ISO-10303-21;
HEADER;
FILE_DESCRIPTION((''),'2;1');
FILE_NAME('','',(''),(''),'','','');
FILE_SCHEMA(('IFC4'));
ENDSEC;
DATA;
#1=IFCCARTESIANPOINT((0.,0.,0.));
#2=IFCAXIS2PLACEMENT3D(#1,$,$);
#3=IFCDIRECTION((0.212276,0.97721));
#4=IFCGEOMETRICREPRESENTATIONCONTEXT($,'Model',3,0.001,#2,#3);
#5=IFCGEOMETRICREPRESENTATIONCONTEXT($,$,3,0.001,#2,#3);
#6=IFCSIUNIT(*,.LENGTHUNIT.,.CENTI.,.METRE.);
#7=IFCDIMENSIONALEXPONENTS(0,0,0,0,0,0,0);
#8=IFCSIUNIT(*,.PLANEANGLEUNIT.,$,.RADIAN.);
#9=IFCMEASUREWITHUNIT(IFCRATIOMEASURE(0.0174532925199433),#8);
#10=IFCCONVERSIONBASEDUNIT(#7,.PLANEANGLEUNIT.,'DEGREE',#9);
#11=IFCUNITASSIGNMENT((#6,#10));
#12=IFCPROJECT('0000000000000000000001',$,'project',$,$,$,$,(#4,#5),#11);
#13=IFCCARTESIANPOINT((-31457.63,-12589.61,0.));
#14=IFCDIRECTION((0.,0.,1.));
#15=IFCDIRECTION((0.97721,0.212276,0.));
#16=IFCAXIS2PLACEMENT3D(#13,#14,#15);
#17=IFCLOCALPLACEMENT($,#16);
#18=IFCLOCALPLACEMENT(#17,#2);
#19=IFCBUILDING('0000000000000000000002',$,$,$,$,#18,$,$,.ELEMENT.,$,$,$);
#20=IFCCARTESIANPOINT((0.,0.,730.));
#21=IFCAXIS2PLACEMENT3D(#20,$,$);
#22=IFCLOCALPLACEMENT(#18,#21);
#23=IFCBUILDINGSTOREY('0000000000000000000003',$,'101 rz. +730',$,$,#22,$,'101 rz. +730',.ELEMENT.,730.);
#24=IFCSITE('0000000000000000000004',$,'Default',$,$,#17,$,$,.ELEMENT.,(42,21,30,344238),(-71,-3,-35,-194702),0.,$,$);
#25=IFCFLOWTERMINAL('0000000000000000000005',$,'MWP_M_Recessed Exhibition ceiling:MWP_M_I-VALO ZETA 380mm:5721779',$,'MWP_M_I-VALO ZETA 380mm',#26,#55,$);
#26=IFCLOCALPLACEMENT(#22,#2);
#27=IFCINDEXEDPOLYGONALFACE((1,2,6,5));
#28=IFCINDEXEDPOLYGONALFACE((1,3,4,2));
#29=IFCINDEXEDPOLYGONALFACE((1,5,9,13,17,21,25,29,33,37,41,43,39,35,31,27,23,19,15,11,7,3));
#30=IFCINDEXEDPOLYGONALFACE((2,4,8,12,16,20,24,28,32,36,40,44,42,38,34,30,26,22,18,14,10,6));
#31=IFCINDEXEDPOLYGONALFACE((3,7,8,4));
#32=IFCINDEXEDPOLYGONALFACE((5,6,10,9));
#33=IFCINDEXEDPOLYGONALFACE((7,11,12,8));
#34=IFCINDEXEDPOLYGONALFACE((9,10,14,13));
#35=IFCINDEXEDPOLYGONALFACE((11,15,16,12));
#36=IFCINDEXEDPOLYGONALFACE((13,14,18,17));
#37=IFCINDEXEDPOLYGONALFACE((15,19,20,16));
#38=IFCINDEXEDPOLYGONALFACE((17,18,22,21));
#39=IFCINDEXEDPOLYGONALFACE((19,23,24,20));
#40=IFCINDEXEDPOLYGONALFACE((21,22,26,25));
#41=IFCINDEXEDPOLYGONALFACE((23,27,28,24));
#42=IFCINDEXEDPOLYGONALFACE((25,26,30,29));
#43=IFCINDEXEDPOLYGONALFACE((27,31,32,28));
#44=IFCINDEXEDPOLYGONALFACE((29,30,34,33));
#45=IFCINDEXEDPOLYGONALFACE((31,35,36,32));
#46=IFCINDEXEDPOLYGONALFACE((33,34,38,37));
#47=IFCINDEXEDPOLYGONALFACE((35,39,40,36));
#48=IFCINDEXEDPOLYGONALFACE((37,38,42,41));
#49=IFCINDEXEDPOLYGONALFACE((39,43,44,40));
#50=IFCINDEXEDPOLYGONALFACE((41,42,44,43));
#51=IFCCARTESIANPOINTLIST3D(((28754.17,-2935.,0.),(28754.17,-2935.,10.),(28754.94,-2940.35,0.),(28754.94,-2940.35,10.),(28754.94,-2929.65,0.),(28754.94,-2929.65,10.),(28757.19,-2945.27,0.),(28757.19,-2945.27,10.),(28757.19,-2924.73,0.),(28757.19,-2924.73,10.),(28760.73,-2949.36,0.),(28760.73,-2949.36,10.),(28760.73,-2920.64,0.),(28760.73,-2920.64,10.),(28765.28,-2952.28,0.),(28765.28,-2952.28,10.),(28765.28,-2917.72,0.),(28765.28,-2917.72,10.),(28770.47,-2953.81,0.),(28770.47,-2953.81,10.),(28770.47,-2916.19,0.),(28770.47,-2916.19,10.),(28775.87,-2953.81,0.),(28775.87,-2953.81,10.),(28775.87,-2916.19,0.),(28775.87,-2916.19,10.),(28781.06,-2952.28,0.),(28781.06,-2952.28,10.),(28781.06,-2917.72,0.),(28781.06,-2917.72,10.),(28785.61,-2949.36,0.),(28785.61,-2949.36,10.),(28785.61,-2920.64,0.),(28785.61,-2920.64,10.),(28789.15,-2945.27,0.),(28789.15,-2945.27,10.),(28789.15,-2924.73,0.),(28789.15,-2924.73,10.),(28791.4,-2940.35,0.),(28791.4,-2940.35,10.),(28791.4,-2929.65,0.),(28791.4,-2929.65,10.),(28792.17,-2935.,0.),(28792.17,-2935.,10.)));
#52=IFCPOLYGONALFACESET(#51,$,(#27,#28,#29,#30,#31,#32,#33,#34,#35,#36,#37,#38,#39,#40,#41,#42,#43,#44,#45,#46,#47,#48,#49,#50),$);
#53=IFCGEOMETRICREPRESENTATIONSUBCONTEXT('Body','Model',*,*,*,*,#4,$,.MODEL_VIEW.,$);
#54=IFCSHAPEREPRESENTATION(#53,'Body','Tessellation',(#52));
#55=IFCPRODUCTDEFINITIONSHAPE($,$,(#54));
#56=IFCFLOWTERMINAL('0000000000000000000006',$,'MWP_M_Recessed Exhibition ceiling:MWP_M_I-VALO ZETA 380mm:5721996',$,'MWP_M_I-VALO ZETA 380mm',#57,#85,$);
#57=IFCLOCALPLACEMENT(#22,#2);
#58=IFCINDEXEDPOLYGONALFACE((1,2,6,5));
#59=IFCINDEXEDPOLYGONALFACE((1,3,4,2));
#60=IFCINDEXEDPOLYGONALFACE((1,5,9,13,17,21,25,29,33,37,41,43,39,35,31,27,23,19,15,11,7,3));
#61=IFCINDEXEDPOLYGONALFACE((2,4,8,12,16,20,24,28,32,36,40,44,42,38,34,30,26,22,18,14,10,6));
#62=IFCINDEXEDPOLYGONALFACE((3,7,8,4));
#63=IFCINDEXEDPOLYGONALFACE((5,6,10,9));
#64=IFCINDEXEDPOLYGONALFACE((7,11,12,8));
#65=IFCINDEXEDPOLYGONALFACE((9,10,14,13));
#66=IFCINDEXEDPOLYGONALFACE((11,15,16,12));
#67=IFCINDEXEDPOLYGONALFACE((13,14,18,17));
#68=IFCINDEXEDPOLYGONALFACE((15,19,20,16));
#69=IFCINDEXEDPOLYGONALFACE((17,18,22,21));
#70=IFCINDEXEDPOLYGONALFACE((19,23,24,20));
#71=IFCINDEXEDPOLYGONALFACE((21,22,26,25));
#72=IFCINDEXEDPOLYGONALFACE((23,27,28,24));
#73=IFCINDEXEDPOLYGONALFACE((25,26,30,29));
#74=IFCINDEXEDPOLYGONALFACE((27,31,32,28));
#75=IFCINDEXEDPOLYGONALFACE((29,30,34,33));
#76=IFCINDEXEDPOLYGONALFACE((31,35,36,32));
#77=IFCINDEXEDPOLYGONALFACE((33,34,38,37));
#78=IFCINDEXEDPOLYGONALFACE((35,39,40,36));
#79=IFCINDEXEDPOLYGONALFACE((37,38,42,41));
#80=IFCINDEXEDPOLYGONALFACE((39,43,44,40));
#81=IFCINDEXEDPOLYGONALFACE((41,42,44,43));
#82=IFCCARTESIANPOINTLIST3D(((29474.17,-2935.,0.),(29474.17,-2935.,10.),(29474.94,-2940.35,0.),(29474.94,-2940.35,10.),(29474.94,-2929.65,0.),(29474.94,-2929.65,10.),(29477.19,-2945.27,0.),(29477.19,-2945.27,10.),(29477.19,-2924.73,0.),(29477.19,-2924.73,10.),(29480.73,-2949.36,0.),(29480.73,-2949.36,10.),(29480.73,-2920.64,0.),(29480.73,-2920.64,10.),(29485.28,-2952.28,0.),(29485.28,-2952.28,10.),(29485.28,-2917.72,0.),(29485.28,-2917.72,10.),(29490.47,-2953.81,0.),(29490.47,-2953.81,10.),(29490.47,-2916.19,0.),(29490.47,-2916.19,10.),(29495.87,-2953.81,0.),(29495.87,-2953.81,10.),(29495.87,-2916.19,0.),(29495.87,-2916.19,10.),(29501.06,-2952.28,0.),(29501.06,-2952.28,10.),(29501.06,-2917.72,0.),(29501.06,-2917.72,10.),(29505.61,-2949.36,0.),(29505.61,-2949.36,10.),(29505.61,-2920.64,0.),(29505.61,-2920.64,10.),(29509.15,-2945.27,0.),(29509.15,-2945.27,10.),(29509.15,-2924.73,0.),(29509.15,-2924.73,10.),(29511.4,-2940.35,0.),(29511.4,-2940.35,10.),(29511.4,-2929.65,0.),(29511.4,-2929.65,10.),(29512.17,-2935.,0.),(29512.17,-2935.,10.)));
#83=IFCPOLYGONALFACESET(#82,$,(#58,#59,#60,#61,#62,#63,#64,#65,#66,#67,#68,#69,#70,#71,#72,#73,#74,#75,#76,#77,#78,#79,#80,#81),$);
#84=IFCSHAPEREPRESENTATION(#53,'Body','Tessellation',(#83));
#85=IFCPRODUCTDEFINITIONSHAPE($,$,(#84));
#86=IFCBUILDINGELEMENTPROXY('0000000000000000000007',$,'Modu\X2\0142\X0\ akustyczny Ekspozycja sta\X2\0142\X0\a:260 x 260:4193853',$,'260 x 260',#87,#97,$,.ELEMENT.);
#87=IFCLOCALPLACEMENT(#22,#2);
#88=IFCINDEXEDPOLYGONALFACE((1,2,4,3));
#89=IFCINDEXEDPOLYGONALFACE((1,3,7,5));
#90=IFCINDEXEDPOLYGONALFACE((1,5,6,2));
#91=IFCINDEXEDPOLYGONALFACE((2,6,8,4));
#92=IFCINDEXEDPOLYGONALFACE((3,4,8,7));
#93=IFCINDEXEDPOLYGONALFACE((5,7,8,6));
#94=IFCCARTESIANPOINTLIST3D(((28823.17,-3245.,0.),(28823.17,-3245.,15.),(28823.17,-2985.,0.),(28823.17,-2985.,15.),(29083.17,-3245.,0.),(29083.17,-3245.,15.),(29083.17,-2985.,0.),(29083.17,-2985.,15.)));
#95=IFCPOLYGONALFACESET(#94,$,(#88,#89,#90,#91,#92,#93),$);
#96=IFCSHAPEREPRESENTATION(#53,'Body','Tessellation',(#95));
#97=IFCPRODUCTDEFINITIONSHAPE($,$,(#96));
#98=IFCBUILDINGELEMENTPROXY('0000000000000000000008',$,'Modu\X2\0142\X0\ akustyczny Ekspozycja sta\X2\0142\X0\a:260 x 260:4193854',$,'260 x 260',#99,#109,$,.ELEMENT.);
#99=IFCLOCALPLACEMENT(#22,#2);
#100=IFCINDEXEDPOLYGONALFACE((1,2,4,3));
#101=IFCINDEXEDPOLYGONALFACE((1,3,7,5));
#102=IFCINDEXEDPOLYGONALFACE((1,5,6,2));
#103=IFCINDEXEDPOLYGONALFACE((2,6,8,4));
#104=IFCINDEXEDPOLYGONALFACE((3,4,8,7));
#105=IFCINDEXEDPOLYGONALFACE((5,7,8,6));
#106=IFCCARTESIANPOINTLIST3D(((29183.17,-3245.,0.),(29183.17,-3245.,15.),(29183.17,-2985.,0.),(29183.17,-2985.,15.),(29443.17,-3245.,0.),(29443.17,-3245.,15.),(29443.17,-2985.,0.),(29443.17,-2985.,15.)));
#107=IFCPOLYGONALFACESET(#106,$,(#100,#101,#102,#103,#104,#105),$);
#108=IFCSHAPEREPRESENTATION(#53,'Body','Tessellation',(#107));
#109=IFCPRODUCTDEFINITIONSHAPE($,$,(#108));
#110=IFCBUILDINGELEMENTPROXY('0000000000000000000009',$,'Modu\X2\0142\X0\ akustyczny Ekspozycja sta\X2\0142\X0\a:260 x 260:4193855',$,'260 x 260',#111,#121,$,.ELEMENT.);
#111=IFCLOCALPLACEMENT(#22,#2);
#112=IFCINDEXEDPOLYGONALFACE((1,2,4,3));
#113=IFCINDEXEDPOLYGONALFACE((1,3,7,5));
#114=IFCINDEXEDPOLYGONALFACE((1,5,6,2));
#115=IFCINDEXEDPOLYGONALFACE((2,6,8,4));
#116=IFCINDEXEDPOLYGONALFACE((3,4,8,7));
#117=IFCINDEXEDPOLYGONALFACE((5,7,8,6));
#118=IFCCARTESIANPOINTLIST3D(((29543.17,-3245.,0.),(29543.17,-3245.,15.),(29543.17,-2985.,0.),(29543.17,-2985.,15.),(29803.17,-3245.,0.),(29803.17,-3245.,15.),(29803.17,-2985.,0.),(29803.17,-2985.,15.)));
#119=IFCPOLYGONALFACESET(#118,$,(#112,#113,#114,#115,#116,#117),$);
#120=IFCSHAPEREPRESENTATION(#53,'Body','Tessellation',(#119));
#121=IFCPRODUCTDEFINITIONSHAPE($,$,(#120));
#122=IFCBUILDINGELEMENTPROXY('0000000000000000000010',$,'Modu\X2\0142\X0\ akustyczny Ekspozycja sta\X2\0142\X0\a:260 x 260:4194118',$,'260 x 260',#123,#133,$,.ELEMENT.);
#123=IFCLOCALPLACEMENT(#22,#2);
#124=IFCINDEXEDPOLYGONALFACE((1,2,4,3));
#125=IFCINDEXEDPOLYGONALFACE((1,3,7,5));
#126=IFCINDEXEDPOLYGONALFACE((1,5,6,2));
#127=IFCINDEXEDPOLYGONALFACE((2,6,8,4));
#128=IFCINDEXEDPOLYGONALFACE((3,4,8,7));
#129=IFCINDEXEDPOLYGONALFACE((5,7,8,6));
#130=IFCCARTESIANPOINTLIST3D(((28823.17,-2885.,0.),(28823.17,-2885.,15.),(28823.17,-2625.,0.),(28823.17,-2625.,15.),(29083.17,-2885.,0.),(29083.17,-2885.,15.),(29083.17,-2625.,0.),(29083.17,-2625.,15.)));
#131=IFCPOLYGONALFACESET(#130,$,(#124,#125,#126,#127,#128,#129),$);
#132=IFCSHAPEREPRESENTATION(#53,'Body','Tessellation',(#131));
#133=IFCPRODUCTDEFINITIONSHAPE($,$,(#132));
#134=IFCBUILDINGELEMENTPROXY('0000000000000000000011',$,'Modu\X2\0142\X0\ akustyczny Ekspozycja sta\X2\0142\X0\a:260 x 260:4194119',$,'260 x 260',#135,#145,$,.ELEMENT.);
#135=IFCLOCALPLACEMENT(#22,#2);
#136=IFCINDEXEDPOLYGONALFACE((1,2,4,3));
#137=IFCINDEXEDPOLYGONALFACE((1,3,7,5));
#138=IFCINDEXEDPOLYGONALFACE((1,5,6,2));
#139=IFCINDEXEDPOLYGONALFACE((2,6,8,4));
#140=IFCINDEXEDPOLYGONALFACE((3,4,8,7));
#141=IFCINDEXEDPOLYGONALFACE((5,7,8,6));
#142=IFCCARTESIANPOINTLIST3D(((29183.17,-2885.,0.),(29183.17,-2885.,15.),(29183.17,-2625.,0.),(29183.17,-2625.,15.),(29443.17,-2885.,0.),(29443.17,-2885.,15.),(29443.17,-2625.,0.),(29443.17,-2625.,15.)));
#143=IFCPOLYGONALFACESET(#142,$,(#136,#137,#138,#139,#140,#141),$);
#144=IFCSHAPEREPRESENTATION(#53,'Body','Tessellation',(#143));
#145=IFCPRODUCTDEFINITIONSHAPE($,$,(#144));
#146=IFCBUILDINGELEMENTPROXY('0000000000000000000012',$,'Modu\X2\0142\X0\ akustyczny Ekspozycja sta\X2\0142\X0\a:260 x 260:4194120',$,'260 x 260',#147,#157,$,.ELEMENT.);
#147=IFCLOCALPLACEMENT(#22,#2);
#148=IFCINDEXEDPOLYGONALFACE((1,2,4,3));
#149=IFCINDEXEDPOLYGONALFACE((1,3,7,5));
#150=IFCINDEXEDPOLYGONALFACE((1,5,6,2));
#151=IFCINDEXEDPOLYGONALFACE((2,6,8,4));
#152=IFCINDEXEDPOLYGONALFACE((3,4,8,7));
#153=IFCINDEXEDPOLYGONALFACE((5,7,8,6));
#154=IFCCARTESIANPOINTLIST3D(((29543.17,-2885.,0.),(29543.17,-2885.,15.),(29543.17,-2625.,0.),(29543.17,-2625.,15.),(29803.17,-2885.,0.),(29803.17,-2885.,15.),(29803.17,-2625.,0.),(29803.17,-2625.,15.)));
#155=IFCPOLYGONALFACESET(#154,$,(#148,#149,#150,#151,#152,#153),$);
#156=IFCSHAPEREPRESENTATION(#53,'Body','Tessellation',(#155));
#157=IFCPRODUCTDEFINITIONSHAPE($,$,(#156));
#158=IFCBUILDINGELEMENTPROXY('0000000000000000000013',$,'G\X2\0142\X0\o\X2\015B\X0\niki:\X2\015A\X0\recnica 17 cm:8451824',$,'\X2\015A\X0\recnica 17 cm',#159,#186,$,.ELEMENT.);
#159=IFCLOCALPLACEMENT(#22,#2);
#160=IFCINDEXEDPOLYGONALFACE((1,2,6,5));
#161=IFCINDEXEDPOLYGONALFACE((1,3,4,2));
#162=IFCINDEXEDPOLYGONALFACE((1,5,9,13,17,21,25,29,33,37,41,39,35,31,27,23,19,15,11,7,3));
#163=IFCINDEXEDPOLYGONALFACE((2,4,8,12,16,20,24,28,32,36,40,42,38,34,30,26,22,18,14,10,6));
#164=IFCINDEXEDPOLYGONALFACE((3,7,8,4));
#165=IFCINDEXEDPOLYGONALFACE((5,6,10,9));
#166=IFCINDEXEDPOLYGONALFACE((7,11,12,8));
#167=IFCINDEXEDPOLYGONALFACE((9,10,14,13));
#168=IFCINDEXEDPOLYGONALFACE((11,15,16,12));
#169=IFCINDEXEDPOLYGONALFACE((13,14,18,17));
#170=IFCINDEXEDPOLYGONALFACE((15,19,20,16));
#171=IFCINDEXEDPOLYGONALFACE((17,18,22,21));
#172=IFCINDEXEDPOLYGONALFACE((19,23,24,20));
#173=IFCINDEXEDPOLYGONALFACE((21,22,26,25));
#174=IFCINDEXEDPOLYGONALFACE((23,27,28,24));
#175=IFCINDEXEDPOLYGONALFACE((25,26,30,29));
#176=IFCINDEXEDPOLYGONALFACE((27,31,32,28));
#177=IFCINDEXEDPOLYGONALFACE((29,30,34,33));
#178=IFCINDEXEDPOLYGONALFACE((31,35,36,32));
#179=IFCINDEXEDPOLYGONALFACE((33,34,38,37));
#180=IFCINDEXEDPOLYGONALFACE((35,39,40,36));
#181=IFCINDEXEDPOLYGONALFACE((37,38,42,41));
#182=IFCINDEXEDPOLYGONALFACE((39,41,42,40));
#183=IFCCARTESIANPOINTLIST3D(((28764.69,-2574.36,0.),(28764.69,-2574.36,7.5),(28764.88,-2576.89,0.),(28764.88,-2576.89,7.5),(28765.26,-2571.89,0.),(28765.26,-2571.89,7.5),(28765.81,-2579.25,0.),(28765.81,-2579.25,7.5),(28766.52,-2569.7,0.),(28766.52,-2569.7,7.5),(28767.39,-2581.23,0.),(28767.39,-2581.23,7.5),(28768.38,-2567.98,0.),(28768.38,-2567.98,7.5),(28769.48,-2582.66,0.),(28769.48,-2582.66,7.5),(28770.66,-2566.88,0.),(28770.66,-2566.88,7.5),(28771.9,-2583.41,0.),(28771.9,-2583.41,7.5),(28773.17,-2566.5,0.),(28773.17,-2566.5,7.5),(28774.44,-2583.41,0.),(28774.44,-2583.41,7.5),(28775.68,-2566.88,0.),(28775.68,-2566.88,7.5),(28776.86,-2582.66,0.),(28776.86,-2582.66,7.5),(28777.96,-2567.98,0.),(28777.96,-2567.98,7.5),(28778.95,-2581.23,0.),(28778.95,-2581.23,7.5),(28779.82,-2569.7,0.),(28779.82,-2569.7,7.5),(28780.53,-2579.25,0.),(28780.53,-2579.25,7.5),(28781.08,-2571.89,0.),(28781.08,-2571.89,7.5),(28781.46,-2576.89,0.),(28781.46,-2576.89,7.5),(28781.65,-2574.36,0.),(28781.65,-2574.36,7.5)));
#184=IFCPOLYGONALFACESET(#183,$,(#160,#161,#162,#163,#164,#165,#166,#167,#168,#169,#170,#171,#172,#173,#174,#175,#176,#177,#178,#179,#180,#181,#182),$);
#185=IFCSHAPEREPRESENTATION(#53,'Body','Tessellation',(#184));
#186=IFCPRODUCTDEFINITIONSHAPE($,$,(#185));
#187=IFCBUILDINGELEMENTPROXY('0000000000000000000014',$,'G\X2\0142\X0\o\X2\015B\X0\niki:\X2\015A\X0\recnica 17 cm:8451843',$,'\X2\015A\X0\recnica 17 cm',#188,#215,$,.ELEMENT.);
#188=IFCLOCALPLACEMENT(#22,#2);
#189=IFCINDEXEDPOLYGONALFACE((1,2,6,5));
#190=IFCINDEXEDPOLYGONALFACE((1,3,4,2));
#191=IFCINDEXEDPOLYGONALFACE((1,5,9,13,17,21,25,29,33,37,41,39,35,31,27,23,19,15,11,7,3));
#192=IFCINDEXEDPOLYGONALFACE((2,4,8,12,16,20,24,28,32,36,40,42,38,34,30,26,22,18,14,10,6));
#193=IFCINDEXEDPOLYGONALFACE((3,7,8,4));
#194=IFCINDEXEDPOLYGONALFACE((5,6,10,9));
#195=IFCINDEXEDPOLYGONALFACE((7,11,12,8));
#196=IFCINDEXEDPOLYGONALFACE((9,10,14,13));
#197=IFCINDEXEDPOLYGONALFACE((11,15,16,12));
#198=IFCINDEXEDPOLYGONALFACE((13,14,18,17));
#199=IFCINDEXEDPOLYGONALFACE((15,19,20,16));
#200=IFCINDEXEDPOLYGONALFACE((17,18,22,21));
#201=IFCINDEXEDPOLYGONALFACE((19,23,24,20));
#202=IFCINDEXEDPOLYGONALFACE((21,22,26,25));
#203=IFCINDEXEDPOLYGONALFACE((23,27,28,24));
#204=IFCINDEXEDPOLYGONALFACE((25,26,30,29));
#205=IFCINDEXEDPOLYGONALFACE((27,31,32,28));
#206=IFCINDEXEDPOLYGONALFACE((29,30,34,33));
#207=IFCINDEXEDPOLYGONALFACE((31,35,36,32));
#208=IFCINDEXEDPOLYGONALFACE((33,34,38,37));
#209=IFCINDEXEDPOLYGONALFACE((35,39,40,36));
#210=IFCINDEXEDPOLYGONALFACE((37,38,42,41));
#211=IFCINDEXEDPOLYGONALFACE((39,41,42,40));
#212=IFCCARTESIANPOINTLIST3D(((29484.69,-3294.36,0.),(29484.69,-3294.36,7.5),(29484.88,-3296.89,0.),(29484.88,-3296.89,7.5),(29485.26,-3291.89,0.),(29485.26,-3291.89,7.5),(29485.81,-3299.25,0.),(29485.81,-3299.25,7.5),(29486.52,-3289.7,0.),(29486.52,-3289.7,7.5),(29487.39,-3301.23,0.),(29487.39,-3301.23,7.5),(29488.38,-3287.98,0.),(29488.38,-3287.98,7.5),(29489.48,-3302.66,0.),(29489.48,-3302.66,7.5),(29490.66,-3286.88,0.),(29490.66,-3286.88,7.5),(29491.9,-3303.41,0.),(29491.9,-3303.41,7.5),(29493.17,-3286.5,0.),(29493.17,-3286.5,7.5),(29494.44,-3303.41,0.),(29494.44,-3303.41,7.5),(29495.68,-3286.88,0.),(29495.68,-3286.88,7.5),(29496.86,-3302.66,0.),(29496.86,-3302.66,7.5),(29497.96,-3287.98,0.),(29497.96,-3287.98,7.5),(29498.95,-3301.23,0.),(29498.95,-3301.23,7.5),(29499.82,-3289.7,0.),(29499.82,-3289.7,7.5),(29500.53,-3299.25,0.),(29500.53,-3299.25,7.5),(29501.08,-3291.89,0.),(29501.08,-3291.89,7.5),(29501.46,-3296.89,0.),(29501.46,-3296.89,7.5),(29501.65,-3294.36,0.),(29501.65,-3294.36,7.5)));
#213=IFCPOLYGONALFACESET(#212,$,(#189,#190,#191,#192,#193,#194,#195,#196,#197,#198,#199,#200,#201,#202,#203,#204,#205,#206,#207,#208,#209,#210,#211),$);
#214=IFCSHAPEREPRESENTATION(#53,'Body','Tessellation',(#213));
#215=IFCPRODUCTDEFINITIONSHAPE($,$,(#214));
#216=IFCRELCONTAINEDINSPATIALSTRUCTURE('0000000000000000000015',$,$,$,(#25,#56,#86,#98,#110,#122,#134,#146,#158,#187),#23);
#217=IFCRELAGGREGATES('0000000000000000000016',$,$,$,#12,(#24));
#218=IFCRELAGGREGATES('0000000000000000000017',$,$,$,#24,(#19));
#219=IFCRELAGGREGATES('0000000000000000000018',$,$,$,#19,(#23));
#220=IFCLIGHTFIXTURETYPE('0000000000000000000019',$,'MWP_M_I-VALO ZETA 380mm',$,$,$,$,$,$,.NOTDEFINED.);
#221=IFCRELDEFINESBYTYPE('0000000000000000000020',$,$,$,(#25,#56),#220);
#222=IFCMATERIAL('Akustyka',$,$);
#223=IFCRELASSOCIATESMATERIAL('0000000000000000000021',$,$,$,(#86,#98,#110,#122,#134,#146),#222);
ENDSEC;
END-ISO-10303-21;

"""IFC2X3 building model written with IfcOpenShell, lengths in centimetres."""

from ifc_helpers import new_model, entity, si_unit, converted_unit, direction, frame, frame_2d, origin, origin_2d_with_axis, place, context, subcontext, project, spatial, rectangle, circle, extrude, source, transform, mapped, material, type_object, type_shapes, element, save


model = new_model("IFC2X3")

# Units and contexts
model_context = context("Model", 3, precision=0.001, world=origin(), true_north=direction((0.212276, 0.97721)))
context_of_model = context(None, 3, precision=0.001, world=origin(), true_north=direction((0.212276, 0.97721)))
body_context = subcontext(model_context, "Body", "Model", "MODEL_VIEW")
ifc_project = project(units=[si_unit("LENGTHUNIT", "METRE", prefix="CENTI"), converted_unit("PLANEANGLEUNIT", "DEGREE", entity("IfcRatioMeasure", 0.0174532925199433), si_unit("PLANEANGLEUNIT", "RADIAN"), dimensions=[0, 0, 0, 0, 0, 0, 0])], contexts=[model_context, context_of_model])

# Site, building, storey
site_placement = place(None, frame((-31457.63, -12589.61, 0.0), z_axis=(0.0, 0.0, 1.0), x_axis=(0.97721, 0.212276, 0.0)))
site = spatial("IfcSite", under=ifc_project, at=site_placement, Name="Default", CompositionType="ELEMENT", RefLatitude=(42, 21, 30, 344238), RefLongitude=(-71, -3, -35, -194702), RefElevation=0.0)
building_placement = place(site_placement, origin())
building = spatial("IfcBuilding", under=site, at=building_placement, CompositionType="ELEMENT")
storey_placement = place(building_placement, frame((0.0, 0.0, 730.0)))
storey = spatial("IfcBuildingStorey", under=building, at=storey_placement, Name="101 rz. +730", LongName="101 rz. +730", CompositionType="ELEMENT", Elevation=730.0)

# Flow terminals
light_fixture_type = type_object("IfcLightFixtureType", Name="MWP_M_I-VALO ZETA 380mm", PredefinedType="NOTDEFINED")
shared_shape_1 = source(origin(), body_context, "Body", "SweptSolid", [
    extrude(circle(Radius=19.0, at=frame_2d((0.0, 0.0), x_axis=(1.0, 0.0))), frame((0.0, 0.0, -10.0)), (0.0, 0.0, 1.0), 10.0),
])
type_shapes(light_fixture_type, [shared_shape_1])
for number, where, z_axis, x_axis, name in (
    (1, (28773.17, -2935.0, 0.0), (0.0, 0.0, -1.0), (1.0, 0.0, 0.0), "MWP_M_Recessed Exhibition ceiling:MWP_M_I-VALO ZETA 380mm:5721779"),
    (2, (29493.17, -2935.0, 0.0), (0.0, 0.0, -1.0), (1.0, 0.0, 0.0), "MWP_M_Recessed Exhibition ceiling:MWP_M_I-VALO ZETA 380mm:5721996"),
):
    element("IfcFlowTerminal", number, at=place(storey_placement, frame(where, z_axis=z_axis, x_axis=x_axis)), inside=storey, type_object=light_fixture_type, Name=name, ObjectType="MWP_M_I-VALO ZETA 380mm", context=body_context, shape_type="MappedRepresentation", body=[
        mapped(shared_shape_1, transform((0.0, 0.0, 0.0), scale=1.0)),
    ])

# Building element proxies
ifc_material_1 = material(Name="Akustyka")
shared_shape_2 = source(origin(), body_context, "Body", "SweptSolid", [
    extrude(rectangle(XDim=260.0, YDim=260.0, at=origin_2d_with_axis()), frame((0.0, 0.0, -15.0), z_axis=(0.0, 0.0, 1.0), x_axis=(-1.0, 0.0, 0.0)), (0.0, 0.0, 1.0), 15.0),
])
for number, where, z_axis, x_axis, name in (
    (3, (28953.17, -3115.0, 0.0), (0.0, 0.0, -1.0), (1.0, 0.0, 0.0), "Moduł akustyczny Ekspozycja stała:260 x 260:4193853"),
    (4, (29313.17, -3115.0, 0.0), (0.0, 0.0, -1.0), (1.0, 0.0, 0.0), "Moduł akustyczny Ekspozycja stała:260 x 260:4193854"),
    (5, (29673.17, -3115.0, 0.0), (0.0, 0.0, -1.0), (1.0, 0.0, 0.0), "Moduł akustyczny Ekspozycja stała:260 x 260:4193855"),
    (6, (28953.17, -2755.0, 0.0), (0.0, 0.0, -1.0), (1.0, 0.0, 0.0), "Moduł akustyczny Ekspozycja stała:260 x 260:4194118"),
    (7, (29313.17, -2755.0, 0.0), (0.0, 0.0, -1.0), (1.0, 0.0, 0.0), "Moduł akustyczny Ekspozycja stała:260 x 260:4194119"),
    (8, (29673.17, -2755.0, 0.0), (0.0, 0.0, -1.0), (1.0, 0.0, 0.0), "Moduł akustyczny Ekspozycja stała:260 x 260:4194120"),
):
    element("IfcBuildingElementProxy", number, at=place(storey_placement, frame(where, z_axis=z_axis, x_axis=x_axis)), inside=storey, material=ifc_material_1, Name=name, ObjectType="260 x 260", CompositionType="ELEMENT", context=body_context, shape_type="MappedRepresentation", body=[
        mapped(shared_shape_2, transform((0.0, 0.0, 0.0), scale=1.0)),
    ])
shared_shape_3 = source(origin(), body_context, "Body", "SweptSolid", [
    extrude(circle(Radius=8.5, at=frame_2d((0.0, 0.0), x_axis=(1.0, 0.0))), frame((0.0, 0.0, 0.0), z_axis=(0.0, 0.0, 1.0), x_axis=(0.0, 1.0, 0.0)), (0.0, 0.0, 1.0), 7.5),
])
for number, where, name in (
    (9, (28773.17, -2575.0, 0.0), "Głośniki:Śrecnica 17 cm:8451824"),
    (10, (29493.17, -3295.0, 0.0), "Głośniki:Śrecnica 17 cm:8451843"),
):
    element("IfcBuildingElementProxy", number, at=place(storey_placement, frame(where)), inside=storey, Name=name, ObjectType="Śrecnica 17 cm", CompositionType="ELEMENT", context=body_context, shape_type="MappedRepresentation", body=[
        mapped(shared_shape_3, transform((0.0, 0.0, 0.0), scale=1.0)),
    ])

save(model, "model.ifc")
